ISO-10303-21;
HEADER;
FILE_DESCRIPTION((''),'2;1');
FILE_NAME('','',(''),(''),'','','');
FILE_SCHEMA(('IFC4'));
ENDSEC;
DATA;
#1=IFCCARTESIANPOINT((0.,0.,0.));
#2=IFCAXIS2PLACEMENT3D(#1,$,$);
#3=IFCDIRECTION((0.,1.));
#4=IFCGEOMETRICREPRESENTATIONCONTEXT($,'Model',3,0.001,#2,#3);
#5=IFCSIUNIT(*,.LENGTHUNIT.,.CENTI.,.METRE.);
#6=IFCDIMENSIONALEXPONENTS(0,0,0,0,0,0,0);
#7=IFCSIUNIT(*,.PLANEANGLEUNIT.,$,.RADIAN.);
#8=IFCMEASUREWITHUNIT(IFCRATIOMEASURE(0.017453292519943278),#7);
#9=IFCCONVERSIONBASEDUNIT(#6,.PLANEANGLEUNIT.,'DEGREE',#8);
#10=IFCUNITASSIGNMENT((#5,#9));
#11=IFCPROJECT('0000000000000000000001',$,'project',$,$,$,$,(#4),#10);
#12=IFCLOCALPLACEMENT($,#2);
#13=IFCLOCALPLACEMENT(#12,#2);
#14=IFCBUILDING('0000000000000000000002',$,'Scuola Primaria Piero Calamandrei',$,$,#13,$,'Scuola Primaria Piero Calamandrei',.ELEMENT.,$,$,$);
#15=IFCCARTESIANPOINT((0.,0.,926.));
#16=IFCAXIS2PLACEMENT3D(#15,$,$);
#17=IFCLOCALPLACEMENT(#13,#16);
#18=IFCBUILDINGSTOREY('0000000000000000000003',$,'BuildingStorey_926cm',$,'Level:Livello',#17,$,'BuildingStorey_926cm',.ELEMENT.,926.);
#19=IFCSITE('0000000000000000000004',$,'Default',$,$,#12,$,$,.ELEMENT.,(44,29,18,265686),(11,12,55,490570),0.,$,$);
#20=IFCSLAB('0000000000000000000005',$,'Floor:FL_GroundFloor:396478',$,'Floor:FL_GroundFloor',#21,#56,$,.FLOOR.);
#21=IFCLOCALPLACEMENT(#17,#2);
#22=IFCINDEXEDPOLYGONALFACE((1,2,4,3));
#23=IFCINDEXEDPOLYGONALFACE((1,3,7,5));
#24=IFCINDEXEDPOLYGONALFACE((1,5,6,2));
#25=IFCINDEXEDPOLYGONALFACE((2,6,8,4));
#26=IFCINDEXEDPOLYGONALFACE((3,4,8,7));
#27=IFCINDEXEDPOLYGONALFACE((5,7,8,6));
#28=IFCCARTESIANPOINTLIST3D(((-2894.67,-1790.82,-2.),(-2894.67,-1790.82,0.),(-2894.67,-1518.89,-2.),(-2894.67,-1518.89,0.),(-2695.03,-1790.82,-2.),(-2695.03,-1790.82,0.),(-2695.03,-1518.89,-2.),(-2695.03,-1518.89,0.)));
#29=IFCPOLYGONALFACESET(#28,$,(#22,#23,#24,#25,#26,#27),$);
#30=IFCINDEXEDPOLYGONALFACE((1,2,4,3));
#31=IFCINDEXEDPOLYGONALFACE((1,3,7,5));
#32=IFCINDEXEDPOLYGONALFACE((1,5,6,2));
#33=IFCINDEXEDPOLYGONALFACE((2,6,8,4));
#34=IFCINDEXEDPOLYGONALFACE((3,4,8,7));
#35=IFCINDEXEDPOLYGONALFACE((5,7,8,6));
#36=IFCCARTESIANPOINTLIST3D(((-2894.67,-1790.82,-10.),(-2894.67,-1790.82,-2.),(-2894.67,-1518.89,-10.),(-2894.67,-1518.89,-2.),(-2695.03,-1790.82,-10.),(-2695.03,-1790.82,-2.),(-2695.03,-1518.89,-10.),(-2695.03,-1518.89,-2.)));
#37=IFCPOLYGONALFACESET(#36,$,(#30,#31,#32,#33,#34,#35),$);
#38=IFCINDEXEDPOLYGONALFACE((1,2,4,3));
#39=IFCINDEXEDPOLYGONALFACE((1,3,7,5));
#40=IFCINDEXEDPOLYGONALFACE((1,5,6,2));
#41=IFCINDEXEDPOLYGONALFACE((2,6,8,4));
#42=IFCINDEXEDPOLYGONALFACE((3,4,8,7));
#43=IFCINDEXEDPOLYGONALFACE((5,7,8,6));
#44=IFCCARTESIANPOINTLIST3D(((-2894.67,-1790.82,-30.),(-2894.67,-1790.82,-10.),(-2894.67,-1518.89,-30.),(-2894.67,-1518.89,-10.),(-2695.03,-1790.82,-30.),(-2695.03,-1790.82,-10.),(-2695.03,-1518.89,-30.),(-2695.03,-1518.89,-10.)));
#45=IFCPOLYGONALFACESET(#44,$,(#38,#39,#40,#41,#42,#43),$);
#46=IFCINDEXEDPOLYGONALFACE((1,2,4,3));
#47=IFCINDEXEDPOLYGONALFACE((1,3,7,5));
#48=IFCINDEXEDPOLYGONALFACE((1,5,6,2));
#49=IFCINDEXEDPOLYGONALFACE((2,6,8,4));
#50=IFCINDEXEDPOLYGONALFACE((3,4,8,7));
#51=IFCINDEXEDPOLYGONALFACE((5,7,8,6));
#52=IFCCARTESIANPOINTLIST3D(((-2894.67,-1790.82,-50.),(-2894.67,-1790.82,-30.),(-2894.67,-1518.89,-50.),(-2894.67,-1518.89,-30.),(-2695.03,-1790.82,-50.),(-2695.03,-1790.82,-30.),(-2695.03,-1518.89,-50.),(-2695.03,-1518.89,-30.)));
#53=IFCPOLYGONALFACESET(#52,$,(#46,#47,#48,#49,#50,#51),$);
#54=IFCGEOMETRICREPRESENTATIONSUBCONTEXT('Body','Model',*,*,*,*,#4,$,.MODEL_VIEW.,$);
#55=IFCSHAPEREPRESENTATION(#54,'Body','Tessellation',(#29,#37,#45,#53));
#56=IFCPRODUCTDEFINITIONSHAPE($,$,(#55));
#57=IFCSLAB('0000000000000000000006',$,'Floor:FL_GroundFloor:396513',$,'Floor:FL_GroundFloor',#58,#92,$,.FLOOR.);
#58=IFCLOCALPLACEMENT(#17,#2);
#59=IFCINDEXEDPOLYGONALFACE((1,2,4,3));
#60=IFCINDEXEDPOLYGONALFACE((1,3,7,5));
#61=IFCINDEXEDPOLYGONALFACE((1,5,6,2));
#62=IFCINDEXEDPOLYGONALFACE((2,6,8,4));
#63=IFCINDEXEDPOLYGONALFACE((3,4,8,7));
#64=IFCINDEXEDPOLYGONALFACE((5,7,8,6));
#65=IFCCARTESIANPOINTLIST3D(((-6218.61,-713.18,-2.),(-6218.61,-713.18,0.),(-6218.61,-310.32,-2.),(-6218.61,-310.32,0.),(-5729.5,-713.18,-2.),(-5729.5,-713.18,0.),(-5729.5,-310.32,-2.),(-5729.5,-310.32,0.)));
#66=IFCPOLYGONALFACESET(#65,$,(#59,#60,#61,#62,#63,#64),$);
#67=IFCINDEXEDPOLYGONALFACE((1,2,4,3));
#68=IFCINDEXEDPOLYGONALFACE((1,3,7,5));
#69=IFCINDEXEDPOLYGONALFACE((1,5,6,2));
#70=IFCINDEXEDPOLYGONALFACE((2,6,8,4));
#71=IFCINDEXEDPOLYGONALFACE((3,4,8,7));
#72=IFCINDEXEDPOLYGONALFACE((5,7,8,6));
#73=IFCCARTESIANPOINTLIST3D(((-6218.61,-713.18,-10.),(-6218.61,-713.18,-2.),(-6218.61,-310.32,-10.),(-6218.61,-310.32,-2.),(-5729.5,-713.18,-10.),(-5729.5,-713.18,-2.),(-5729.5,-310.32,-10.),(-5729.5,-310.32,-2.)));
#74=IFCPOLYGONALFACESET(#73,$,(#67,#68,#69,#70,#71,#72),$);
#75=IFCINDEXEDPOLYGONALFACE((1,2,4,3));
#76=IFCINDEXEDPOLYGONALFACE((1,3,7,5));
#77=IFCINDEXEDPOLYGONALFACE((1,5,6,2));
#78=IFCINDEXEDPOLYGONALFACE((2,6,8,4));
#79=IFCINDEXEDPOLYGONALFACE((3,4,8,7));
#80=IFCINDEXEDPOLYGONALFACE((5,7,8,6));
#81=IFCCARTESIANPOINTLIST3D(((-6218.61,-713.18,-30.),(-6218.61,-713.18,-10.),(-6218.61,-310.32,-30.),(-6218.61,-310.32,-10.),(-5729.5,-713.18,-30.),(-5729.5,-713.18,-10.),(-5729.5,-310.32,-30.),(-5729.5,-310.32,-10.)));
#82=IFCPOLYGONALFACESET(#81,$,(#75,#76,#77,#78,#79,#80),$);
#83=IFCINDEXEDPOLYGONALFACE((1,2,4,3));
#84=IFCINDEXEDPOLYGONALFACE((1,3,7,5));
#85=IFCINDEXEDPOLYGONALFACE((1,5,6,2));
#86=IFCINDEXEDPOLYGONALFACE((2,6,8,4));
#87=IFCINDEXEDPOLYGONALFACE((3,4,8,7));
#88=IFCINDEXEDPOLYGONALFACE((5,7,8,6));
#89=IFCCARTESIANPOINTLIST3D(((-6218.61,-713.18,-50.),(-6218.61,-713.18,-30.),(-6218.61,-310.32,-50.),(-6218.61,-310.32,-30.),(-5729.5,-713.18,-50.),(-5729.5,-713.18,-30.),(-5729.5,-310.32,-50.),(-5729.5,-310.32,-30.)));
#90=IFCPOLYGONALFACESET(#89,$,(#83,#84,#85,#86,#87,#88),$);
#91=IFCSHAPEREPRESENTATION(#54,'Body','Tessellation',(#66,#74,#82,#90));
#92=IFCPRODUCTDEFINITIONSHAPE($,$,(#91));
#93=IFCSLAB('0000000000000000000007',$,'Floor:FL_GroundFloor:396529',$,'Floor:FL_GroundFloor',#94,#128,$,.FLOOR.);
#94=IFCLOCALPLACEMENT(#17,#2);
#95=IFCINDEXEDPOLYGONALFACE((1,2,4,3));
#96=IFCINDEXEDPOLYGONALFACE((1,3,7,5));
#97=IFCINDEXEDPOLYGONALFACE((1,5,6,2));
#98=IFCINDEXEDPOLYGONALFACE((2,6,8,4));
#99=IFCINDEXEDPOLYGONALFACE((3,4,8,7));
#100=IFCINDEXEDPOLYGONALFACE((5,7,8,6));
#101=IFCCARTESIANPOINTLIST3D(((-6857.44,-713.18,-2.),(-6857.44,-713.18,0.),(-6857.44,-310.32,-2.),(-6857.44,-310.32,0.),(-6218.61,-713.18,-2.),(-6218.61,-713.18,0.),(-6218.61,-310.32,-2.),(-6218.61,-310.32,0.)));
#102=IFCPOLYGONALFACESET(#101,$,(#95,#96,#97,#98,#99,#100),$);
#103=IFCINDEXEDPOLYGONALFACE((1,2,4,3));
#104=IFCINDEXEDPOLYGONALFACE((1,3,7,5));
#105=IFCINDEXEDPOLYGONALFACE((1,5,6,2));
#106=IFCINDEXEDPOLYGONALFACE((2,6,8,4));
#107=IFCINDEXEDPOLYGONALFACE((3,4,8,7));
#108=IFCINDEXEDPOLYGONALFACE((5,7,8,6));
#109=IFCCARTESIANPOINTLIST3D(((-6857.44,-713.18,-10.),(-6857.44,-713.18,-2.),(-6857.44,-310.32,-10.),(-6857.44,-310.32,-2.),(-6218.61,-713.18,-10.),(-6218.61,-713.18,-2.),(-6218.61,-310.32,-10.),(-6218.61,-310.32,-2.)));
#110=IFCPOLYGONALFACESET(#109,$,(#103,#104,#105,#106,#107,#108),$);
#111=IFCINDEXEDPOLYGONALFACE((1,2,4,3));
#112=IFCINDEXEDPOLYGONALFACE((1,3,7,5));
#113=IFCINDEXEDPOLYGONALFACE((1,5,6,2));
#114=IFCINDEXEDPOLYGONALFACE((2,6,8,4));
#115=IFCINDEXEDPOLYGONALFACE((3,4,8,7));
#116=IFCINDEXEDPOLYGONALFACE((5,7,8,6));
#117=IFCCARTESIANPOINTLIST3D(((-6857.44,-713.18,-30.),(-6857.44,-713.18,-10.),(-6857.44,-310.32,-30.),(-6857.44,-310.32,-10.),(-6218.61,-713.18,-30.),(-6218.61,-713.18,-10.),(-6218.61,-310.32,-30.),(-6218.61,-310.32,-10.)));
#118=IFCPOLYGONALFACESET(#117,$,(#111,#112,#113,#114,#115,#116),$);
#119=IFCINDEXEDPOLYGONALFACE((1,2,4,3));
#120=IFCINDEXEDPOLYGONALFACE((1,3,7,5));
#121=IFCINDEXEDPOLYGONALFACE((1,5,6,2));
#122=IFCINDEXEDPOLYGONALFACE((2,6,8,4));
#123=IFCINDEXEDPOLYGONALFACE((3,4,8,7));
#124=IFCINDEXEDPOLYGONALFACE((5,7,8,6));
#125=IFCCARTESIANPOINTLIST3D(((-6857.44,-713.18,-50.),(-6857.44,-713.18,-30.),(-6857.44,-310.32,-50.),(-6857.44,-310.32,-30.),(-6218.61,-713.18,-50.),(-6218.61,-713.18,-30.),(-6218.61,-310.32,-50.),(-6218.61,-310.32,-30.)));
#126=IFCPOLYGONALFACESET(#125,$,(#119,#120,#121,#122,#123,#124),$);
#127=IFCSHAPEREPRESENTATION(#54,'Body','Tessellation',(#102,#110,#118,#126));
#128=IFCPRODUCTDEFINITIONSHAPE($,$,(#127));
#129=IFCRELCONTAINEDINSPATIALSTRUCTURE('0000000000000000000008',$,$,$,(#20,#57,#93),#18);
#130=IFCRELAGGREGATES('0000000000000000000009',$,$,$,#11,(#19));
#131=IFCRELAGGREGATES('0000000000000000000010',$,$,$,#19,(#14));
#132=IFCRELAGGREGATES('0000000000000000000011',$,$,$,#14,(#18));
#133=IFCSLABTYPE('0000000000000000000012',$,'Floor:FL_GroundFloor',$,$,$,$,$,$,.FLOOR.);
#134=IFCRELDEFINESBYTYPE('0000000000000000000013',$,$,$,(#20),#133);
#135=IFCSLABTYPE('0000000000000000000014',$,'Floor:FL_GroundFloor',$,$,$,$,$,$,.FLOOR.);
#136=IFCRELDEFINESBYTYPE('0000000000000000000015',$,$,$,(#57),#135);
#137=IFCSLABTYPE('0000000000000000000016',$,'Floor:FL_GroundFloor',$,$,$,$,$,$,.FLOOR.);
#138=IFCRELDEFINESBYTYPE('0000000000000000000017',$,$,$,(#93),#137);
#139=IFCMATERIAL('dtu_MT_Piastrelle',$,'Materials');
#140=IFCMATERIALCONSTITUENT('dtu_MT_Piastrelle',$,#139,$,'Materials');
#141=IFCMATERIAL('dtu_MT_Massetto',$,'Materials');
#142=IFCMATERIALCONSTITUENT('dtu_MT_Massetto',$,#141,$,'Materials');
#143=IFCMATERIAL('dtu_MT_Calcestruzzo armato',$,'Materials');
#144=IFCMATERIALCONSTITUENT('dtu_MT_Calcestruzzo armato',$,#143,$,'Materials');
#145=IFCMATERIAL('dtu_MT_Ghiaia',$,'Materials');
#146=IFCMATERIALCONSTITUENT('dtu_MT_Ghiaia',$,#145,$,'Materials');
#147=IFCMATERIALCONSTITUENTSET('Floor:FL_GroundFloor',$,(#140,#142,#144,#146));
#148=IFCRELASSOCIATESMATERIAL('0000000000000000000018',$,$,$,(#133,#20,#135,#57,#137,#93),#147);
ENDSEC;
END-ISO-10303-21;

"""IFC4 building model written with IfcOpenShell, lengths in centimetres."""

from ifc_helpers import new_model, entity, si_unit, converted_unit, direction, frame, origin, place, context, subcontext, project, spatial, indexed_curve, outline, extrude, material, constituent, constituent_set, type_object, element, save


model = new_model("IFC4")

# Units and contexts
model_context = context("Model", 3, precision=0.001, world=origin(), true_north=direction((0.0, 1.0)))
body_context = subcontext(model_context, "Body", "Model", "MODEL_VIEW")
ifc_project = project(units=[si_unit("LENGTHUNIT", "METRE", prefix="CENTI"), converted_unit("PLANEANGLEUNIT", "DEGREE", entity("IfcRatioMeasure", 0.017453292519943278), si_unit("PLANEANGLEUNIT", "RADIAN"), dimensions=[0, 0, 0, 0, 0, 0, 0])], contexts=[model_context])

# Site, building, storey
site_placement = place(None, origin())
site = spatial("IfcSite", under=ifc_project, at=site_placement, Name="Default", CompositionType="ELEMENT", RefLatitude=(44, 29, 18, 265686), RefLongitude=(11, 12, 55, 490570), RefElevation=0.0)
building_placement = place(site_placement, origin())
building = spatial("IfcBuilding", under=site, at=building_placement, Name="Scuola Primaria Piero Calamandrei", LongName="Scuola Primaria Piero Calamandrei", CompositionType="ELEMENT")
storey_placement = place(building_placement, frame((0.0, 0.0, 926.0)))
storey = spatial("IfcBuildingStorey", under=building, at=storey_placement, Name="BuildingStorey_926cm", ObjectType="Level:Livello", LongName="BuildingStorey_926cm", CompositionType="ELEMENT", Elevation=926.0)

# Slabs
ifc_material_1 = material(Name="dtu_MT_Piastrelle", Category="Materials")
ifc_constituent_1 = constituent(ifc_material_1, Name="dtu_MT_Piastrelle", Category="Materials")
ifc_material_2 = material(Name="dtu_MT_Massetto", Category="Materials")
ifc_constituent_2 = constituent(ifc_material_2, Name="dtu_MT_Massetto", Category="Materials")
ifc_material_3 = material(Name="dtu_MT_Calcestruzzo armato", Category="Materials")
ifc_constituent_3 = constituent(ifc_material_3, Name="dtu_MT_Calcestruzzo armato", Category="Materials")
ifc_material_4 = material(Name="dtu_MT_Ghiaia", Category="Materials")
ifc_constituent_4 = constituent(ifc_material_4, Name="dtu_MT_Ghiaia", Category="Materials")
ifc_constituent_set_1 = constituent_set(constituents=[ifc_constituent_1, ifc_constituent_2, ifc_constituent_3, ifc_constituent_4], Name="Floor:FL_GroundFloor")
slab_type_1 = type_object("IfcSlabType", Name="Floor:FL_GroundFloor", PredefinedType="FLOOR", material=ifc_constituent_set_1)
slab_1_placement = place(storey_placement, origin())
element("IfcSlab", 1, at=slab_1_placement, inside=storey, type_object=slab_type_1, material=ifc_constituent_set_1, Name="Floor:FL_GroundFloor:396478", ObjectType="Floor:FL_GroundFloor", PredefinedType="FLOOR", context=body_context, shape_type="SweptSolid", body=[
    extrude(outline(indexed_curve([(-135.96, -99.82), (135.96, -99.82), (135.96, 99.82), (-135.96, 99.82), (-135.96, -99.82)], self_intersect=False)), frame((-2794.85, -1654.86, -2.0), z_axis=(0.0, 0.0, 1.0), x_axis=(0.0, 1.0, 0.0)), (0.0, 0.0, 1.0), 2.0),
    extrude(outline(indexed_curve([(-135.96, -99.82), (135.96, -99.82), (135.96, 99.82), (-135.96, 99.82), (-135.96, -99.82)], self_intersect=False)), frame((-2794.85, -1654.86, -10.0), z_axis=(0.0, 0.0, 1.0), x_axis=(0.0, 1.0, 0.0)), (0.0, 0.0, 1.0), 8.0),
    extrude(outline(indexed_curve([(-135.96, -99.82), (135.96, -99.82), (135.96, 99.82), (-135.96, 99.82), (-135.96, -99.82)], self_intersect=False)), frame((-2794.85, -1654.86, -30.0), z_axis=(0.0, 0.0, 1.0), x_axis=(0.0, 1.0, 0.0)), (0.0, 0.0, 1.0), 20.0),
    extrude(outline(indexed_curve([(-135.96, -99.82), (135.96, -99.82), (135.96, 99.82), (-135.96, 99.82), (-135.96, -99.82)], self_intersect=False)), frame((-2794.85, -1654.86, -50.0), z_axis=(0.0, 0.0, 1.0), x_axis=(0.0, 1.0, 0.0)), (0.0, 0.0, 1.0), 20.0),
])
slab_type_2 = type_object("IfcSlabType", Name="Floor:FL_GroundFloor", PredefinedType="FLOOR", material=ifc_constituent_set_1)
slab_2_placement = place(storey_placement, origin())
element("IfcSlab", 2, at=slab_2_placement, inside=storey, type_object=slab_type_2, material=ifc_constituent_set_1, Name="Floor:FL_GroundFloor:396513", ObjectType="Floor:FL_GroundFloor", PredefinedType="FLOOR", context=body_context, shape_type="SweptSolid", body=[
    extrude(outline(indexed_curve([(-244.55, -201.43), (244.55, -201.43), (244.55, 201.43), (-244.55, 201.43), (-244.55, -201.43)], self_intersect=False)), frame((-5974.05, -511.75, -2.0), z_axis=(0.0, 0.0, 1.0), x_axis=(-1.0, 0.0, 0.0)), (0.0, 0.0, 1.0), 2.0),
    extrude(outline(indexed_curve([(-244.55, -201.43), (244.55, -201.43), (244.55, 201.43), (-244.55, 201.43), (-244.55, -201.43)], self_intersect=False)), frame((-5974.05, -511.75, -10.0), z_axis=(0.0, 0.0, 1.0), x_axis=(-1.0, 0.0, 0.0)), (0.0, 0.0, 1.0), 8.0),
    extrude(outline(indexed_curve([(-244.55, -201.43), (244.55, -201.43), (244.55, 201.43), (-244.55, 201.43), (-244.55, -201.43)], self_intersect=False)), frame((-5974.05, -511.75, -30.0), z_axis=(0.0, 0.0, 1.0), x_axis=(-1.0, 0.0, 0.0)), (0.0, 0.0, 1.0), 20.0),
    extrude(outline(indexed_curve([(-244.55, -201.43), (244.55, -201.43), (244.55, 201.43), (-244.55, 201.43), (-244.55, -201.43)], self_intersect=False)), frame((-5974.05, -511.75, -50.0), z_axis=(0.0, 0.0, 1.0), x_axis=(-1.0, 0.0, 0.0)), (0.0, 0.0, 1.0), 20.0),
])
slab_type_3 = type_object("IfcSlabType", Name="Floor:FL_GroundFloor", PredefinedType="FLOOR", material=ifc_constituent_set_1)
slab_3_placement = place(storey_placement, origin())
element("IfcSlab", 3, at=slab_3_placement, inside=storey, type_object=slab_type_3, material=ifc_constituent_set_1, Name="Floor:FL_GroundFloor:396529", ObjectType="Floor:FL_GroundFloor", PredefinedType="FLOOR", context=body_context, shape_type="SweptSolid", body=[
    extrude(outline(indexed_curve([(-319.42, -201.43), (319.42, -201.43), (319.42, 201.43), (-319.42, 201.43), (-319.42, -201.43)], self_intersect=False)), frame((-6538.03, -511.75, -2.0), z_axis=(0.0, 0.0, 1.0), x_axis=(-1.0, 0.0, 0.0)), (0.0, 0.0, 1.0), 2.0),
    extrude(outline(indexed_curve([(-319.42, -201.43), (319.42, -201.43), (319.42, 201.43), (-319.42, 201.43), (-319.42, -201.43)], self_intersect=False)), frame((-6538.03, -511.75, -10.0), z_axis=(0.0, 0.0, 1.0), x_axis=(-1.0, 0.0, 0.0)), (0.0, 0.0, 1.0), 8.0),
    extrude(outline(indexed_curve([(-319.42, -201.43), (319.42, -201.43), (319.42, 201.43), (-319.42, 201.43), (-319.42, -201.43)], self_intersect=False)), frame((-6538.03, -511.75, -30.0), z_axis=(0.0, 0.0, 1.0), x_axis=(-1.0, 0.0, 0.0)), (0.0, 0.0, 1.0), 20.0),
    extrude(outline(indexed_curve([(-319.42, -201.43), (319.42, -201.43), (319.42, 201.43), (-319.42, 201.43), (-319.42, -201.43)], self_intersect=False)), frame((-6538.03, -511.75, -50.0), z_axis=(0.0, 0.0, 1.0), x_axis=(-1.0, 0.0, 0.0)), (0.0, 0.0, 1.0), 20.0),
])

save(model, "model.ifc")
